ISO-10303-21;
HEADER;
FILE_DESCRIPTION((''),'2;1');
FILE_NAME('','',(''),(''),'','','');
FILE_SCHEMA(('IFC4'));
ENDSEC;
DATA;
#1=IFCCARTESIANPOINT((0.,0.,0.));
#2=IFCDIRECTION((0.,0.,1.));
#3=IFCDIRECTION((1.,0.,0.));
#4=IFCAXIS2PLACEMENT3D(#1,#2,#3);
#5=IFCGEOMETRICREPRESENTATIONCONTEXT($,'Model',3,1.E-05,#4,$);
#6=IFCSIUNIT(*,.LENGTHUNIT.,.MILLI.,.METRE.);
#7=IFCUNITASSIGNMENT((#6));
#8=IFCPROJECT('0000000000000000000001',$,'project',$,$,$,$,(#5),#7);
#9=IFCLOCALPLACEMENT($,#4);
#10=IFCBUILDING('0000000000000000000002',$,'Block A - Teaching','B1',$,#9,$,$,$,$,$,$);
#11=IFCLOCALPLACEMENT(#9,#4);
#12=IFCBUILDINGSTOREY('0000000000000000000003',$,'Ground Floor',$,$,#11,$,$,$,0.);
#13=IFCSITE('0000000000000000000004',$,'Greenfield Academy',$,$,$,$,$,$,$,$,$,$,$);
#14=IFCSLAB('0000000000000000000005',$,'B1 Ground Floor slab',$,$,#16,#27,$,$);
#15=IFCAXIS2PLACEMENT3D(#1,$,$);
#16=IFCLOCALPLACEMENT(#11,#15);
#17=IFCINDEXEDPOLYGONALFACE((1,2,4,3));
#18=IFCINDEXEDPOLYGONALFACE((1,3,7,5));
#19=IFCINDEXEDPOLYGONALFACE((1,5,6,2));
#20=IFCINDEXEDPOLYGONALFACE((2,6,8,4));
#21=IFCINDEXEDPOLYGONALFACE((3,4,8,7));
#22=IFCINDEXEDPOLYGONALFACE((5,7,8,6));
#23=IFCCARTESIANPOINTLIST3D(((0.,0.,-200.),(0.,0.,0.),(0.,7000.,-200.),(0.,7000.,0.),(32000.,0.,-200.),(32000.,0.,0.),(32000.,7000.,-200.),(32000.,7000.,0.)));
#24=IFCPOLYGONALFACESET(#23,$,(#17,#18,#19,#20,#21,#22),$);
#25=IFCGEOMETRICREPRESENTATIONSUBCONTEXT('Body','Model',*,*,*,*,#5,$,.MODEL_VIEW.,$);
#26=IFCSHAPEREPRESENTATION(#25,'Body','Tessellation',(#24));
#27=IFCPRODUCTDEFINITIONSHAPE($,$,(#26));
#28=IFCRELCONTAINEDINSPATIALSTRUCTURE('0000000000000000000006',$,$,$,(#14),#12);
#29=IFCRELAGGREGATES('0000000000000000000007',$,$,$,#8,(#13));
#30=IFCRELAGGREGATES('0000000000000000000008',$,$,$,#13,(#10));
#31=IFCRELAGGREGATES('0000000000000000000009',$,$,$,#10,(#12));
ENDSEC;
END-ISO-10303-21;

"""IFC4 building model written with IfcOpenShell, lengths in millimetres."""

from ifc_helpers import new_model, si_unit, frame, origin_with_axes, place, context, subcontext, project, spatial, indexed_curve, outline, extrude, element, save


model = new_model("IFC4")

# Units and contexts
model_context = context("Model", 3, precision=1e-05, world=origin_with_axes())
body_context = subcontext(model_context, "Body", "Model", "MODEL_VIEW")
ifc_project = project(units=[si_unit("LENGTHUNIT", "METRE", prefix="MILLI")], contexts=[model_context])

# Site, building, storey
site = spatial("IfcSite", under=ifc_project, Name="Greenfield Academy")
building_placement = place(None, origin_with_axes())
building = spatial("IfcBuilding", under=site, at=building_placement, Name="Block A - Teaching", Description="B1")
storey_placement = place(building_placement, origin_with_axes())
storey = spatial("IfcBuildingStorey", under=building, at=storey_placement, Name="Ground Floor", Elevation=0.0)

# Slab
slab_placement = place(storey_placement, frame((0.0, 0.0, -200.0), z_axis=(0.0, 0.0, 1.0), x_axis=(1.0, 0.0, 0.0)))
element("IfcSlab", 1, at=slab_placement, inside=storey, Name="B1 Ground Floor slab", context=body_context, shape_type="SweptSolid", body=[
    extrude(outline(indexed_curve([(0.0, 0.0), (0.0, 7000.0), (32000.0, 7000.0), (32000.0, 0.0), (0.0, 0.0)], self_intersect=False)), origin_with_axes(), (0.0, 0.0, 1.0), 200.0),
])

save(model, "model.ifc")
